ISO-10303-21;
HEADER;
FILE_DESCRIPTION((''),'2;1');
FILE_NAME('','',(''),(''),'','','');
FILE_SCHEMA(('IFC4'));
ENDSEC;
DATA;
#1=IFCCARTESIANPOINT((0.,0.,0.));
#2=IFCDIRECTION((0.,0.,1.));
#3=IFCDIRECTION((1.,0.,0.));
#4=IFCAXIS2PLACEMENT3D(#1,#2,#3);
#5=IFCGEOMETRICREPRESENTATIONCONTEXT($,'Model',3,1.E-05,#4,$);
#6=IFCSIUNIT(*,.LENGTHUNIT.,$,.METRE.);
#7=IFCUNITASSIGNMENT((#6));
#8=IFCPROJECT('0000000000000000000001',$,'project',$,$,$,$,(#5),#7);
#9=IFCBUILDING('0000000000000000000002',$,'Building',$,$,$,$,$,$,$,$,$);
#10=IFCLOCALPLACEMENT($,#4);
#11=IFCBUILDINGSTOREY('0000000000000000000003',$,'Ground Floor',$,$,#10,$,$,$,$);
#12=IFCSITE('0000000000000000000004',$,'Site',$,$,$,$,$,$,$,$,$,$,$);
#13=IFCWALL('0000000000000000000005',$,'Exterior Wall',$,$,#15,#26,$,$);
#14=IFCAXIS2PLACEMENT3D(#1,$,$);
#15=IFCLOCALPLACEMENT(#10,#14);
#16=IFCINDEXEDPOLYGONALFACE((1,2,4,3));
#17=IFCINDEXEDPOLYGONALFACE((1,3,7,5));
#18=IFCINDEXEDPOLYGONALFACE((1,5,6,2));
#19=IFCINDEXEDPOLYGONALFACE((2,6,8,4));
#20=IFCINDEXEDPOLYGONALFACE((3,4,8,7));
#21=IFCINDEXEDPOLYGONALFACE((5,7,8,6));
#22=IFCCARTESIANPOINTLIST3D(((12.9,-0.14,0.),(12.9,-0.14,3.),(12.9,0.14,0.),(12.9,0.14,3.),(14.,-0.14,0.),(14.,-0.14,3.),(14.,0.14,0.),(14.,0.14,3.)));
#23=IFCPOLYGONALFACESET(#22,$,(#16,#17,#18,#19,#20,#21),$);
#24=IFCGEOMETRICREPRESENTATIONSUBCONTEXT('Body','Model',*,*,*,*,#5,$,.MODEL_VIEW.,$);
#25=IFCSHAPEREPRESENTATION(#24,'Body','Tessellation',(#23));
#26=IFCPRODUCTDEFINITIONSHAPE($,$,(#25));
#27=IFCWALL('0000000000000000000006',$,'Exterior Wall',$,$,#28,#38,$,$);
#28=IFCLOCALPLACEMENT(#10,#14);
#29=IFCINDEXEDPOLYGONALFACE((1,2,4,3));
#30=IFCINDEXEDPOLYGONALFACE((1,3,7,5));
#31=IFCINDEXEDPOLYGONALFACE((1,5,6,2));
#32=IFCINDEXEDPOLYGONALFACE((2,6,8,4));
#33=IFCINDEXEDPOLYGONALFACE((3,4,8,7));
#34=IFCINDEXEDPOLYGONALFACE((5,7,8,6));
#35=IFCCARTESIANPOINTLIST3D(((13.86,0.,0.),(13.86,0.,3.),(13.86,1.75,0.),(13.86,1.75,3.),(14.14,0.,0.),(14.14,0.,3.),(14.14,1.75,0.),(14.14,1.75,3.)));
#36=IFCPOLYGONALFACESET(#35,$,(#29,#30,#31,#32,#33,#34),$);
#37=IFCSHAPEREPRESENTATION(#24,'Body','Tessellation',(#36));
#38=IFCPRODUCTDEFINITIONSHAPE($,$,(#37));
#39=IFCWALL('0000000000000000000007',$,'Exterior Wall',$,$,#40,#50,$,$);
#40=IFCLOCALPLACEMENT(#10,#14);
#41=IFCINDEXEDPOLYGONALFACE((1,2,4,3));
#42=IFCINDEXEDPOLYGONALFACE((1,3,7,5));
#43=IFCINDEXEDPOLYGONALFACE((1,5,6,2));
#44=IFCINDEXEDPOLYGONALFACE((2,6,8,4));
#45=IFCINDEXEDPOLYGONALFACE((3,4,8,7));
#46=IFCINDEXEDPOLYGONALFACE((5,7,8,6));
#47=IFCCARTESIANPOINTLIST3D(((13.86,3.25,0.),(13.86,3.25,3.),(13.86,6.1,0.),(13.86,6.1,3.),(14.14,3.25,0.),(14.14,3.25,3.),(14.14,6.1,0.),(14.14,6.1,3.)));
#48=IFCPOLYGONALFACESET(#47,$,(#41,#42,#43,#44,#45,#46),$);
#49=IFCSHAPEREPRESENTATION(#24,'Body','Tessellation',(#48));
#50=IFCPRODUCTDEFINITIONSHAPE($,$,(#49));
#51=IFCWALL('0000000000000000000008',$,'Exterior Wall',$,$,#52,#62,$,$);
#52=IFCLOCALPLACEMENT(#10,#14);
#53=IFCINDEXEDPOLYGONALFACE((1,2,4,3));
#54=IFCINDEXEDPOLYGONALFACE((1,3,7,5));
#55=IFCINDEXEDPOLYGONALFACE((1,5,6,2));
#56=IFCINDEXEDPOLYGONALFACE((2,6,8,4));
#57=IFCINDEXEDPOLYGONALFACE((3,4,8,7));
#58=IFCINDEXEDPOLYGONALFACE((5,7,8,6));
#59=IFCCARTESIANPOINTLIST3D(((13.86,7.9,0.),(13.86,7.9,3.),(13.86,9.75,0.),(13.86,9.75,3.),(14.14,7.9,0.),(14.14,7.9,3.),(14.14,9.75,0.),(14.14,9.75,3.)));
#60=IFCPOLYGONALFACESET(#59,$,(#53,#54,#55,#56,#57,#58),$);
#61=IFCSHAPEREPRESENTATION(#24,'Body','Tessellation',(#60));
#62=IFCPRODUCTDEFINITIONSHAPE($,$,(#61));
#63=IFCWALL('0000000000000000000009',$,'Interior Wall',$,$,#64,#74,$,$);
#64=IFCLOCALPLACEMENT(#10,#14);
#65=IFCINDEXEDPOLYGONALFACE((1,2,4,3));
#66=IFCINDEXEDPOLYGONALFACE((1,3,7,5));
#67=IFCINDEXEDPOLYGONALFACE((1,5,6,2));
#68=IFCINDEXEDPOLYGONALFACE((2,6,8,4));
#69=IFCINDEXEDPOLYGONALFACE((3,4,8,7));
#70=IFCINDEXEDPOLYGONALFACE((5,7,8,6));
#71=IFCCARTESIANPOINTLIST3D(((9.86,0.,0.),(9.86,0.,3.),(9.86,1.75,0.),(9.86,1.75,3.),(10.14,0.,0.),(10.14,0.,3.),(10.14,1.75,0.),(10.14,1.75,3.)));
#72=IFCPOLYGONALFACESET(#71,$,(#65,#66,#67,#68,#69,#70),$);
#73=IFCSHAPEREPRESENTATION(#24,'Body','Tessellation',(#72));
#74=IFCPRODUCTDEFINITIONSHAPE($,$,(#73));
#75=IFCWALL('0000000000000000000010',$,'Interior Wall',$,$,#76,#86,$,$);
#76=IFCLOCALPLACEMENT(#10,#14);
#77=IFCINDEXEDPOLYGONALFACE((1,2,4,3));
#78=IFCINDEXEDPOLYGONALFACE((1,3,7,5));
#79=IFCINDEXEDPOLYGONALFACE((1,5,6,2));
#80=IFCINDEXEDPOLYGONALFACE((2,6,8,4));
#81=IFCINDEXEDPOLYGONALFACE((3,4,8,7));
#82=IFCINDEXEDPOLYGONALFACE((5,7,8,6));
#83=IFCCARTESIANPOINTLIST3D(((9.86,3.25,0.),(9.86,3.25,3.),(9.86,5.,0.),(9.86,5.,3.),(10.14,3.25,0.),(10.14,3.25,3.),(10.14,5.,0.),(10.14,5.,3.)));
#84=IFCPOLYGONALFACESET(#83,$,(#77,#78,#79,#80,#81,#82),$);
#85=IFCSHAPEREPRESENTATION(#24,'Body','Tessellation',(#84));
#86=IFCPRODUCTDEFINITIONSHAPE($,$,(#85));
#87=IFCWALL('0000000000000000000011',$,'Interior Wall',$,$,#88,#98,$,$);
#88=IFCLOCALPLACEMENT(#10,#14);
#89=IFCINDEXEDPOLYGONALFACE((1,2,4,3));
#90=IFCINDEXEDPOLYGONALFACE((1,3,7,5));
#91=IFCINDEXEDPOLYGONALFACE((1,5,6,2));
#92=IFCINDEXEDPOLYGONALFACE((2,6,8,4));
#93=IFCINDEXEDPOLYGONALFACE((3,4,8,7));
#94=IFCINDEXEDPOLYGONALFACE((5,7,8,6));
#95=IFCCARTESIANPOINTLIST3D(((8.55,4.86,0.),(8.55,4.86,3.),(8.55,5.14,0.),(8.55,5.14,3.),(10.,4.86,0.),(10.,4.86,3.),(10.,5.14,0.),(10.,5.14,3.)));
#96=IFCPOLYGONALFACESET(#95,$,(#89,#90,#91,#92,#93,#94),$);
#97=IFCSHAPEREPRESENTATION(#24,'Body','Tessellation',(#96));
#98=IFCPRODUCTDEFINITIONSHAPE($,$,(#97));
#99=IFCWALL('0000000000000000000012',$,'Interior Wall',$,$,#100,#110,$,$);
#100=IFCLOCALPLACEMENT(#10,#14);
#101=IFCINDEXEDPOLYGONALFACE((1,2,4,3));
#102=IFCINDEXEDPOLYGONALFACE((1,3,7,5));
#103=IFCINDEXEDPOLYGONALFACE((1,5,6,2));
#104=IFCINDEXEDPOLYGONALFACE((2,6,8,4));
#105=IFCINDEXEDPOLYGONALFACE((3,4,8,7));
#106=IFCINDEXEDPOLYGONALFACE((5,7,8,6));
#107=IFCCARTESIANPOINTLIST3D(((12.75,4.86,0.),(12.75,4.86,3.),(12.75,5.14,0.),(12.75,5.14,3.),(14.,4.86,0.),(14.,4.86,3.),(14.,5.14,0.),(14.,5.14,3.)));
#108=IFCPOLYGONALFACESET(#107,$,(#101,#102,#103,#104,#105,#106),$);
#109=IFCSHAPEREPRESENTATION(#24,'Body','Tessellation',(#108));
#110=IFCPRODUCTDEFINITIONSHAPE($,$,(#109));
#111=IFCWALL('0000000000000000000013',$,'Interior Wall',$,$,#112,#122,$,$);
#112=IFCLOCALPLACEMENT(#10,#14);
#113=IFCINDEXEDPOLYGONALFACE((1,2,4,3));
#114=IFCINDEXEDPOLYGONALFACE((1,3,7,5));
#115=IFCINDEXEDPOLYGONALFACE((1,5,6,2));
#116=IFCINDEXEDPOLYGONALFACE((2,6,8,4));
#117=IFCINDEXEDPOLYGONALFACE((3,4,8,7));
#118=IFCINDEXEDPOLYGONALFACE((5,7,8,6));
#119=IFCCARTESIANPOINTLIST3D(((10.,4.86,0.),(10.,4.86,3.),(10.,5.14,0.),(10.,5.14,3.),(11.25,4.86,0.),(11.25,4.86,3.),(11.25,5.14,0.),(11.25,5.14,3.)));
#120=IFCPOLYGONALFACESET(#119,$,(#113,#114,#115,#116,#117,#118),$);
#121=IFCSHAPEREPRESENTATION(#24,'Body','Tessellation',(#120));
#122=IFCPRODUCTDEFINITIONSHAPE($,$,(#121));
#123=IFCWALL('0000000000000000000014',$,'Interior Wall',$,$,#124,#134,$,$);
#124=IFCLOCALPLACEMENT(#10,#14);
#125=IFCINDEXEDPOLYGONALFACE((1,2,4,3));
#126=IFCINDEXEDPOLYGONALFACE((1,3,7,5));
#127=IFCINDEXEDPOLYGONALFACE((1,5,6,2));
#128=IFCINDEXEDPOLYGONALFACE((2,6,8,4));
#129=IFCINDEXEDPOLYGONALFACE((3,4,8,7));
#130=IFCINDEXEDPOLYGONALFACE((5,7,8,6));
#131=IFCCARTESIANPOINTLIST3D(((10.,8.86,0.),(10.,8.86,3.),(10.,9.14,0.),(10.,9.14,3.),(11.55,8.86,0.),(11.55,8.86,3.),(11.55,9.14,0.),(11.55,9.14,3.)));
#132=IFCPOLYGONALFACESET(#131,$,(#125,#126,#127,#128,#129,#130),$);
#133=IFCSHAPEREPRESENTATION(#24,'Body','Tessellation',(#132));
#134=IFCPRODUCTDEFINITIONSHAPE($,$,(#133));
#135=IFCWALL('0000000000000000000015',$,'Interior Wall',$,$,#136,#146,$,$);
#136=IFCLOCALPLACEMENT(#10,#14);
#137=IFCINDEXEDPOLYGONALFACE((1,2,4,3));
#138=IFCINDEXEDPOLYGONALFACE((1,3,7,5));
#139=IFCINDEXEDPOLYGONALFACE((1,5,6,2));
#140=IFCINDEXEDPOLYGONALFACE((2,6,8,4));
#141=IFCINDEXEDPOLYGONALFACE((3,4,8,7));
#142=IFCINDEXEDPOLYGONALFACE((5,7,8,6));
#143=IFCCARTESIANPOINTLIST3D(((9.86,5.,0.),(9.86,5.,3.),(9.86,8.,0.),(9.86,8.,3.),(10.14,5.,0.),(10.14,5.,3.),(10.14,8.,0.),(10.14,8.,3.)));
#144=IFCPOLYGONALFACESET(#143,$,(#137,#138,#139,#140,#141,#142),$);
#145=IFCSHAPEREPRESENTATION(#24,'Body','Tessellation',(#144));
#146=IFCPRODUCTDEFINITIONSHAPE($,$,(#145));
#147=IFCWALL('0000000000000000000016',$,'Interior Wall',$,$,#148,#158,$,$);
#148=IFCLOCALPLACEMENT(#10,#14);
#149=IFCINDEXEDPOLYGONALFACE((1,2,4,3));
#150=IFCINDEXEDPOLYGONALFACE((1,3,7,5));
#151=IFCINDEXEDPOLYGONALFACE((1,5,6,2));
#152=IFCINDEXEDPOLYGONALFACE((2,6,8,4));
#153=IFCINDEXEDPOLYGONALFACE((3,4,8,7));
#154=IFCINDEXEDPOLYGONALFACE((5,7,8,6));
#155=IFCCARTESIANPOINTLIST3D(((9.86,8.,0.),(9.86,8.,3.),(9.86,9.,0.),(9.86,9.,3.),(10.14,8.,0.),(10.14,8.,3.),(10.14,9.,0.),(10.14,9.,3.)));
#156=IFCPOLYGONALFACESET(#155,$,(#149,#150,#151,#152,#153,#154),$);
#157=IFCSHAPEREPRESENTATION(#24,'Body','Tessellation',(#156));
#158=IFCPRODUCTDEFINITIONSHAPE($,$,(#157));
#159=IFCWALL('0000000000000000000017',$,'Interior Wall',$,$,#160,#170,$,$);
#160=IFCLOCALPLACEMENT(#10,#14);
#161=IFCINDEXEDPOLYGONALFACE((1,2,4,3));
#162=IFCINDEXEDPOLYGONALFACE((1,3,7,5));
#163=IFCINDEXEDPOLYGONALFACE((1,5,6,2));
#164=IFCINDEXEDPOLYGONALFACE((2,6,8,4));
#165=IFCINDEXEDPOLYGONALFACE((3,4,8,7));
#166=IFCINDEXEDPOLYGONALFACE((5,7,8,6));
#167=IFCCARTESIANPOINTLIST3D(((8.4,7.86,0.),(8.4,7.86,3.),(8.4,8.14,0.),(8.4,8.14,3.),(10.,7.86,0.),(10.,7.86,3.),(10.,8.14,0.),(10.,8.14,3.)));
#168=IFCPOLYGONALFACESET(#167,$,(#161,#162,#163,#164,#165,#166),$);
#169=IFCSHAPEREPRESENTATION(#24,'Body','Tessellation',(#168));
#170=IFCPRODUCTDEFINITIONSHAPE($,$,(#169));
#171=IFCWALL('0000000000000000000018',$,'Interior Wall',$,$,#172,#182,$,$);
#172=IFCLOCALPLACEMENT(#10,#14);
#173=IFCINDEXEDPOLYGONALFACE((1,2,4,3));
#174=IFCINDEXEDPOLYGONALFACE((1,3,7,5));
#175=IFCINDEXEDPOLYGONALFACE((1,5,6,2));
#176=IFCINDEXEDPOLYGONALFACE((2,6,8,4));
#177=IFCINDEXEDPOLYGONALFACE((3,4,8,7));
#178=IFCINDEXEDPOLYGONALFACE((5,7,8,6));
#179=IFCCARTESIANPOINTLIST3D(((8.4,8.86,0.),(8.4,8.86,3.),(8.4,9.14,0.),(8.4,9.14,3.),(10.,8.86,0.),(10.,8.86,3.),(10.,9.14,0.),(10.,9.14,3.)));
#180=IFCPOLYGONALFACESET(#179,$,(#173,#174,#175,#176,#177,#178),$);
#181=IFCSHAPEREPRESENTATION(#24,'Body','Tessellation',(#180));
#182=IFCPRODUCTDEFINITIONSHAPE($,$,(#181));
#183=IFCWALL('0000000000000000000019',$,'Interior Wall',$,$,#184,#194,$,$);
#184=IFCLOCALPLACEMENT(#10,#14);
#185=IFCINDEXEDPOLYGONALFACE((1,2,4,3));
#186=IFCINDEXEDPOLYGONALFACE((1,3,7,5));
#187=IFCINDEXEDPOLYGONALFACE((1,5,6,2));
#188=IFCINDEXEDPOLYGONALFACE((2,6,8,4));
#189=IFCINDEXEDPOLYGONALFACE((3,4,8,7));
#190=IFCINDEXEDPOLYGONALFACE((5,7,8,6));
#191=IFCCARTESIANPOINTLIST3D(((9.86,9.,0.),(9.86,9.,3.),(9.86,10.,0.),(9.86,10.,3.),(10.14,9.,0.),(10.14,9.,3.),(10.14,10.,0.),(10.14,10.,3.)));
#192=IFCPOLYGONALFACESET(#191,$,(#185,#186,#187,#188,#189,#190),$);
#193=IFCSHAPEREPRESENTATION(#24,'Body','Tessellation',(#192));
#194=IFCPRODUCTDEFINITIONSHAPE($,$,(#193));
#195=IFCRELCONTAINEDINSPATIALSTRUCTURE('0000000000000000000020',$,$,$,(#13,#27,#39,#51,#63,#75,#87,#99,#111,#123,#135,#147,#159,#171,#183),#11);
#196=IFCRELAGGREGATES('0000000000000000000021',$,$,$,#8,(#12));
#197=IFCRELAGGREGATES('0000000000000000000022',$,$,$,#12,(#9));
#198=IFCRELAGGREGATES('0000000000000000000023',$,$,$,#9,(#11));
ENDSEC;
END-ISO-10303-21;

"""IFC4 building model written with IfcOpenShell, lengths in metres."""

from ifc_helpers import new_model, si_unit, frame, origin_with_axes, place, context, subcontext, project, spatial, indexed_curve, outline, extrude, element, save


model = new_model("IFC4")

# Units and contexts
model_context = context("Model", 3, precision=1e-05, world=origin_with_axes())
body_context = subcontext(model_context, "Body", "Model", "MODEL_VIEW")
ifc_project = project(units=[si_unit("LENGTHUNIT", "METRE")], contexts=[model_context])

# Site, building, storey
site = spatial("IfcSite", under=ifc_project, Name="Site")
building = spatial("IfcBuilding", under=site, Name="Building")
storey_placement = place(None, origin_with_axes())
storey = spatial("IfcBuildingStorey", under=building, at=storey_placement, Name="Ground Floor")

# Walls
wall_1_placement = place(storey_placement, frame((12.9, 0.0, 0.0), z_axis=(0.0, 0.0, 1.0), x_axis=(1.0, 0.0, 0.0)))
element("IfcWall", 1, at=wall_1_placement, inside=storey, Name="Exterior Wall", context=body_context, shape_type="SweptSolid", body=[
    extrude(outline(indexed_curve([(0.0, 0.0), (0.0, 0.28), (1.1, 0.28), (1.1, 0.0), (0.0, 0.0)], self_intersect=False)), frame((0.0, -0.14, 0.0), z_axis=(0.0, 0.0, 1.0), x_axis=(1.0, 0.0, 0.0)), (0.0, 0.0, 1.0), 3.0),
])
wall_2_placement = place(storey_placement, frame((14.0, 0.0, 0.0), z_axis=(0.0, 0.0, 1.0), x_axis=(0.0, 1.0, 0.0)))
element("IfcWall", 2, at=wall_2_placement, inside=storey, Name="Exterior Wall", context=body_context, shape_type="SweptSolid", body=[
    extrude(outline(indexed_curve([(0.0, 0.0), (0.0, 0.28), (1.75, 0.28), (1.75, 0.0), (0.0, 0.0)], self_intersect=False)), frame((0.0, -0.14, 0.0), z_axis=(0.0, 0.0, 1.0), x_axis=(1.0, 0.0, 0.0)), (0.0, 0.0, 1.0), 3.0),
])
wall_3_placement = place(storey_placement, frame((14.0, 3.25, 0.0), z_axis=(0.0, 0.0, 1.0), x_axis=(0.0, 1.0, 0.0)))
element("IfcWall", 3, at=wall_3_placement, inside=storey, Name="Exterior Wall", context=body_context, shape_type="SweptSolid", body=[
    extrude(outline(indexed_curve([(0.0, 0.0), (0.0, 0.28), (2.85, 0.28), (2.85, 0.0), (0.0, 0.0)], self_intersect=False)), frame((0.0, -0.14, 0.0), z_axis=(0.0, 0.0, 1.0), x_axis=(1.0, 0.0, 0.0)), (0.0, 0.0, 1.0), 3.0),
])
wall_4_placement = place(storey_placement, frame((14.0, 7.9, 0.0), z_axis=(0.0, 0.0, 1.0), x_axis=(0.0, 1.0, 0.0)))
element("IfcWall", 4, at=wall_4_placement, inside=storey, Name="Exterior Wall", context=body_context, shape_type="SweptSolid", body=[
    extrude(outline(indexed_curve([(0.0, 0.0), (0.0, 0.28), (1.85, 0.28), (1.85, 0.0), (0.0, 0.0)], self_intersect=False)), frame((0.0, -0.14, 0.0), z_axis=(0.0, 0.0, 1.0), x_axis=(1.0, 0.0, 0.0)), (0.0, 0.0, 1.0), 3.0),
])
for number, where, z_axis, x_axis, name in (
    (5, (10.0, 0.0, 0.0), (0.0, 0.0, 1.0), (0.0, 1.0, 0.0), "Interior Wall"),
    (6, (10.0, 3.25, 0.0), (0.0, 0.0, 1.0), (0.0, 1.0, 0.0), "Interior Wall"),
):
    element("IfcWall", number, at=place(storey_placement, frame(where, z_axis=z_axis, x_axis=x_axis)), inside=storey, Name=name, context=body_context, shape_type="SweptSolid", body=[
        extrude(outline(indexed_curve([(0.0, 0.0), (0.0, 0.28), (1.75, 0.28), (1.75, 0.0), (0.0, 0.0)], self_intersect=False)), frame((0.0, -0.14, 0.0), z_axis=(0.0, 0.0, 1.0), x_axis=(1.0, 0.0, 0.0)), (0.0, 0.0, 1.0), 3.0),
    ])
wall_5_placement = place(storey_placement, frame((10.0, 5.0, 0.0), z_axis=(0.0, 0.0, 1.0), x_axis=(-1.0, 0.0, 0.0)))
element("IfcWall", 7, at=wall_5_placement, inside=storey, Name="Interior Wall", context=body_context, shape_type="SweptSolid", body=[
    extrude(outline(indexed_curve([(0.0, 0.0), (0.0, 0.28), (1.45, 0.28), (1.45, 0.0), (0.0, 0.0)], self_intersect=False)), frame((0.0, -0.14, 0.0), z_axis=(0.0, 0.0, 1.0), x_axis=(1.0, 0.0, 0.0)), (0.0, 0.0, 1.0), 3.0),
])
for number, where, z_axis, x_axis, name in (
    (8, (14.0, 5.0, 0.0), (0.0, 0.0, 1.0), (-1.0, 0.0, 0.0), "Interior Wall"),
    (9, (11.25, 5.0, 0.0), (0.0, 0.0, 1.0), (-1.0, 0.0, 0.0), "Interior Wall"),
):
    element("IfcWall", number, at=place(storey_placement, frame(where, z_axis=z_axis, x_axis=x_axis)), inside=storey, Name=name, context=body_context, shape_type="SweptSolid", body=[
        extrude(outline(indexed_curve([(0.0, 0.0), (0.0, 0.28), (1.25, 0.28), (1.25, 0.0), (0.0, 0.0)], self_intersect=False)), frame((0.0, -0.14, 0.0), z_axis=(0.0, 0.0, 1.0), x_axis=(1.0, 0.0, 0.0)), (0.0, 0.0, 1.0), 3.0),
    ])
wall_6_placement = place(storey_placement, frame((11.55, 9.0, 0.0), z_axis=(0.0, 0.0, 1.0), x_axis=(-1.0, 0.0, 0.0)))
element("IfcWall", 10, at=wall_6_placement, inside=storey, Name="Interior Wall", context=body_context, shape_type="SweptSolid", body=[
    extrude(outline(indexed_curve([(0.0, 0.0), (0.0, 0.28), (1.55, 0.28), (1.55, 0.0), (0.0, 0.0)], self_intersect=False)), frame((0.0, -0.14, 0.0), z_axis=(0.0, 0.0, 1.0), x_axis=(1.0, 0.0, 0.0)), (0.0, 0.0, 1.0), 3.0),
])
wall_7_placement = place(storey_placement, frame((10.0, 8.0, 0.0), z_axis=(0.0, 0.0, 1.0), x_axis=(0.0, -1.0, 0.0)))
element("IfcWall", 11, at=wall_7_placement, inside=storey, Name="Interior Wall", context=body_context, shape_type="SweptSolid", body=[
    extrude(outline(indexed_curve([(0.0, 0.0), (0.0, 0.28), (3.0, 0.28), (3.0, 0.0), (0.0, 0.0)], self_intersect=False)), frame((0.0, -0.14, 0.0), z_axis=(0.0, 0.0, 1.0), x_axis=(1.0, 0.0, 0.0)), (0.0, 0.0, 1.0), 3.0),
])
wall_8_placement = place(storey_placement, frame((10.0, 9.0, 0.0), z_axis=(0.0, 0.0, 1.0), x_axis=(0.0, -1.0, 0.0)))
element("IfcWall", 12, at=wall_8_placement, inside=storey, Name="Interior Wall", context=body_context, shape_type="SweptSolid", body=[
    extrude(outline(indexed_curve([(0.0, 0.0), (0.0, 0.28), (1.0, 0.28), (1.0, 0.0), (0.0, 0.0)], self_intersect=False)), frame((0.0, -0.14, 0.0), z_axis=(0.0, 0.0, 1.0), x_axis=(1.0, 0.0, 0.0)), (0.0, 0.0, 1.0), 3.0),
])
for number, where, z_axis, x_axis, name in (
    (13, (10.0, 8.0, 0.0), (0.0, 0.0, 1.0), (-1.0, 0.0, 0.0), "Interior Wall"),
    (14, (10.0, 9.0, 0.0), (0.0, 0.0, 1.0), (-1.0, 0.0, 0.0), "Interior Wall"),
):
    element("IfcWall", number, at=place(storey_placement, frame(where, z_axis=z_axis, x_axis=x_axis)), inside=storey, Name=name, context=body_context, shape_type="SweptSolid", body=[
        extrude(outline(indexed_curve([(0.0, 0.0), (0.0, 0.28), (1.6, 0.28), (1.6, 0.0), (0.0, 0.0)], self_intersect=False)), frame((0.0, -0.14, 0.0), z_axis=(0.0, 0.0, 1.0), x_axis=(1.0, 0.0, 0.0)), (0.0, 0.0, 1.0), 3.0),
    ])
wall_9_placement = place(storey_placement, frame((10.0, 9.0, 0.0), z_axis=(0.0, 0.0, 1.0), x_axis=(0.0, 1.0, 0.0)))
element("IfcWall", 15, at=wall_9_placement, inside=storey, Name="Interior Wall", context=body_context, shape_type="SweptSolid", body=[
    extrude(outline(indexed_curve([(0.0, 0.0), (0.0, 0.28), (1.0, 0.28), (1.0, 0.0), (0.0, 0.0)], self_intersect=False)), frame((0.0, -0.14, 0.0), z_axis=(0.0, 0.0, 1.0), x_axis=(1.0, 0.0, 0.0)), (0.0, 0.0, 1.0), 3.0),
])

save(model, "model.ifc")
